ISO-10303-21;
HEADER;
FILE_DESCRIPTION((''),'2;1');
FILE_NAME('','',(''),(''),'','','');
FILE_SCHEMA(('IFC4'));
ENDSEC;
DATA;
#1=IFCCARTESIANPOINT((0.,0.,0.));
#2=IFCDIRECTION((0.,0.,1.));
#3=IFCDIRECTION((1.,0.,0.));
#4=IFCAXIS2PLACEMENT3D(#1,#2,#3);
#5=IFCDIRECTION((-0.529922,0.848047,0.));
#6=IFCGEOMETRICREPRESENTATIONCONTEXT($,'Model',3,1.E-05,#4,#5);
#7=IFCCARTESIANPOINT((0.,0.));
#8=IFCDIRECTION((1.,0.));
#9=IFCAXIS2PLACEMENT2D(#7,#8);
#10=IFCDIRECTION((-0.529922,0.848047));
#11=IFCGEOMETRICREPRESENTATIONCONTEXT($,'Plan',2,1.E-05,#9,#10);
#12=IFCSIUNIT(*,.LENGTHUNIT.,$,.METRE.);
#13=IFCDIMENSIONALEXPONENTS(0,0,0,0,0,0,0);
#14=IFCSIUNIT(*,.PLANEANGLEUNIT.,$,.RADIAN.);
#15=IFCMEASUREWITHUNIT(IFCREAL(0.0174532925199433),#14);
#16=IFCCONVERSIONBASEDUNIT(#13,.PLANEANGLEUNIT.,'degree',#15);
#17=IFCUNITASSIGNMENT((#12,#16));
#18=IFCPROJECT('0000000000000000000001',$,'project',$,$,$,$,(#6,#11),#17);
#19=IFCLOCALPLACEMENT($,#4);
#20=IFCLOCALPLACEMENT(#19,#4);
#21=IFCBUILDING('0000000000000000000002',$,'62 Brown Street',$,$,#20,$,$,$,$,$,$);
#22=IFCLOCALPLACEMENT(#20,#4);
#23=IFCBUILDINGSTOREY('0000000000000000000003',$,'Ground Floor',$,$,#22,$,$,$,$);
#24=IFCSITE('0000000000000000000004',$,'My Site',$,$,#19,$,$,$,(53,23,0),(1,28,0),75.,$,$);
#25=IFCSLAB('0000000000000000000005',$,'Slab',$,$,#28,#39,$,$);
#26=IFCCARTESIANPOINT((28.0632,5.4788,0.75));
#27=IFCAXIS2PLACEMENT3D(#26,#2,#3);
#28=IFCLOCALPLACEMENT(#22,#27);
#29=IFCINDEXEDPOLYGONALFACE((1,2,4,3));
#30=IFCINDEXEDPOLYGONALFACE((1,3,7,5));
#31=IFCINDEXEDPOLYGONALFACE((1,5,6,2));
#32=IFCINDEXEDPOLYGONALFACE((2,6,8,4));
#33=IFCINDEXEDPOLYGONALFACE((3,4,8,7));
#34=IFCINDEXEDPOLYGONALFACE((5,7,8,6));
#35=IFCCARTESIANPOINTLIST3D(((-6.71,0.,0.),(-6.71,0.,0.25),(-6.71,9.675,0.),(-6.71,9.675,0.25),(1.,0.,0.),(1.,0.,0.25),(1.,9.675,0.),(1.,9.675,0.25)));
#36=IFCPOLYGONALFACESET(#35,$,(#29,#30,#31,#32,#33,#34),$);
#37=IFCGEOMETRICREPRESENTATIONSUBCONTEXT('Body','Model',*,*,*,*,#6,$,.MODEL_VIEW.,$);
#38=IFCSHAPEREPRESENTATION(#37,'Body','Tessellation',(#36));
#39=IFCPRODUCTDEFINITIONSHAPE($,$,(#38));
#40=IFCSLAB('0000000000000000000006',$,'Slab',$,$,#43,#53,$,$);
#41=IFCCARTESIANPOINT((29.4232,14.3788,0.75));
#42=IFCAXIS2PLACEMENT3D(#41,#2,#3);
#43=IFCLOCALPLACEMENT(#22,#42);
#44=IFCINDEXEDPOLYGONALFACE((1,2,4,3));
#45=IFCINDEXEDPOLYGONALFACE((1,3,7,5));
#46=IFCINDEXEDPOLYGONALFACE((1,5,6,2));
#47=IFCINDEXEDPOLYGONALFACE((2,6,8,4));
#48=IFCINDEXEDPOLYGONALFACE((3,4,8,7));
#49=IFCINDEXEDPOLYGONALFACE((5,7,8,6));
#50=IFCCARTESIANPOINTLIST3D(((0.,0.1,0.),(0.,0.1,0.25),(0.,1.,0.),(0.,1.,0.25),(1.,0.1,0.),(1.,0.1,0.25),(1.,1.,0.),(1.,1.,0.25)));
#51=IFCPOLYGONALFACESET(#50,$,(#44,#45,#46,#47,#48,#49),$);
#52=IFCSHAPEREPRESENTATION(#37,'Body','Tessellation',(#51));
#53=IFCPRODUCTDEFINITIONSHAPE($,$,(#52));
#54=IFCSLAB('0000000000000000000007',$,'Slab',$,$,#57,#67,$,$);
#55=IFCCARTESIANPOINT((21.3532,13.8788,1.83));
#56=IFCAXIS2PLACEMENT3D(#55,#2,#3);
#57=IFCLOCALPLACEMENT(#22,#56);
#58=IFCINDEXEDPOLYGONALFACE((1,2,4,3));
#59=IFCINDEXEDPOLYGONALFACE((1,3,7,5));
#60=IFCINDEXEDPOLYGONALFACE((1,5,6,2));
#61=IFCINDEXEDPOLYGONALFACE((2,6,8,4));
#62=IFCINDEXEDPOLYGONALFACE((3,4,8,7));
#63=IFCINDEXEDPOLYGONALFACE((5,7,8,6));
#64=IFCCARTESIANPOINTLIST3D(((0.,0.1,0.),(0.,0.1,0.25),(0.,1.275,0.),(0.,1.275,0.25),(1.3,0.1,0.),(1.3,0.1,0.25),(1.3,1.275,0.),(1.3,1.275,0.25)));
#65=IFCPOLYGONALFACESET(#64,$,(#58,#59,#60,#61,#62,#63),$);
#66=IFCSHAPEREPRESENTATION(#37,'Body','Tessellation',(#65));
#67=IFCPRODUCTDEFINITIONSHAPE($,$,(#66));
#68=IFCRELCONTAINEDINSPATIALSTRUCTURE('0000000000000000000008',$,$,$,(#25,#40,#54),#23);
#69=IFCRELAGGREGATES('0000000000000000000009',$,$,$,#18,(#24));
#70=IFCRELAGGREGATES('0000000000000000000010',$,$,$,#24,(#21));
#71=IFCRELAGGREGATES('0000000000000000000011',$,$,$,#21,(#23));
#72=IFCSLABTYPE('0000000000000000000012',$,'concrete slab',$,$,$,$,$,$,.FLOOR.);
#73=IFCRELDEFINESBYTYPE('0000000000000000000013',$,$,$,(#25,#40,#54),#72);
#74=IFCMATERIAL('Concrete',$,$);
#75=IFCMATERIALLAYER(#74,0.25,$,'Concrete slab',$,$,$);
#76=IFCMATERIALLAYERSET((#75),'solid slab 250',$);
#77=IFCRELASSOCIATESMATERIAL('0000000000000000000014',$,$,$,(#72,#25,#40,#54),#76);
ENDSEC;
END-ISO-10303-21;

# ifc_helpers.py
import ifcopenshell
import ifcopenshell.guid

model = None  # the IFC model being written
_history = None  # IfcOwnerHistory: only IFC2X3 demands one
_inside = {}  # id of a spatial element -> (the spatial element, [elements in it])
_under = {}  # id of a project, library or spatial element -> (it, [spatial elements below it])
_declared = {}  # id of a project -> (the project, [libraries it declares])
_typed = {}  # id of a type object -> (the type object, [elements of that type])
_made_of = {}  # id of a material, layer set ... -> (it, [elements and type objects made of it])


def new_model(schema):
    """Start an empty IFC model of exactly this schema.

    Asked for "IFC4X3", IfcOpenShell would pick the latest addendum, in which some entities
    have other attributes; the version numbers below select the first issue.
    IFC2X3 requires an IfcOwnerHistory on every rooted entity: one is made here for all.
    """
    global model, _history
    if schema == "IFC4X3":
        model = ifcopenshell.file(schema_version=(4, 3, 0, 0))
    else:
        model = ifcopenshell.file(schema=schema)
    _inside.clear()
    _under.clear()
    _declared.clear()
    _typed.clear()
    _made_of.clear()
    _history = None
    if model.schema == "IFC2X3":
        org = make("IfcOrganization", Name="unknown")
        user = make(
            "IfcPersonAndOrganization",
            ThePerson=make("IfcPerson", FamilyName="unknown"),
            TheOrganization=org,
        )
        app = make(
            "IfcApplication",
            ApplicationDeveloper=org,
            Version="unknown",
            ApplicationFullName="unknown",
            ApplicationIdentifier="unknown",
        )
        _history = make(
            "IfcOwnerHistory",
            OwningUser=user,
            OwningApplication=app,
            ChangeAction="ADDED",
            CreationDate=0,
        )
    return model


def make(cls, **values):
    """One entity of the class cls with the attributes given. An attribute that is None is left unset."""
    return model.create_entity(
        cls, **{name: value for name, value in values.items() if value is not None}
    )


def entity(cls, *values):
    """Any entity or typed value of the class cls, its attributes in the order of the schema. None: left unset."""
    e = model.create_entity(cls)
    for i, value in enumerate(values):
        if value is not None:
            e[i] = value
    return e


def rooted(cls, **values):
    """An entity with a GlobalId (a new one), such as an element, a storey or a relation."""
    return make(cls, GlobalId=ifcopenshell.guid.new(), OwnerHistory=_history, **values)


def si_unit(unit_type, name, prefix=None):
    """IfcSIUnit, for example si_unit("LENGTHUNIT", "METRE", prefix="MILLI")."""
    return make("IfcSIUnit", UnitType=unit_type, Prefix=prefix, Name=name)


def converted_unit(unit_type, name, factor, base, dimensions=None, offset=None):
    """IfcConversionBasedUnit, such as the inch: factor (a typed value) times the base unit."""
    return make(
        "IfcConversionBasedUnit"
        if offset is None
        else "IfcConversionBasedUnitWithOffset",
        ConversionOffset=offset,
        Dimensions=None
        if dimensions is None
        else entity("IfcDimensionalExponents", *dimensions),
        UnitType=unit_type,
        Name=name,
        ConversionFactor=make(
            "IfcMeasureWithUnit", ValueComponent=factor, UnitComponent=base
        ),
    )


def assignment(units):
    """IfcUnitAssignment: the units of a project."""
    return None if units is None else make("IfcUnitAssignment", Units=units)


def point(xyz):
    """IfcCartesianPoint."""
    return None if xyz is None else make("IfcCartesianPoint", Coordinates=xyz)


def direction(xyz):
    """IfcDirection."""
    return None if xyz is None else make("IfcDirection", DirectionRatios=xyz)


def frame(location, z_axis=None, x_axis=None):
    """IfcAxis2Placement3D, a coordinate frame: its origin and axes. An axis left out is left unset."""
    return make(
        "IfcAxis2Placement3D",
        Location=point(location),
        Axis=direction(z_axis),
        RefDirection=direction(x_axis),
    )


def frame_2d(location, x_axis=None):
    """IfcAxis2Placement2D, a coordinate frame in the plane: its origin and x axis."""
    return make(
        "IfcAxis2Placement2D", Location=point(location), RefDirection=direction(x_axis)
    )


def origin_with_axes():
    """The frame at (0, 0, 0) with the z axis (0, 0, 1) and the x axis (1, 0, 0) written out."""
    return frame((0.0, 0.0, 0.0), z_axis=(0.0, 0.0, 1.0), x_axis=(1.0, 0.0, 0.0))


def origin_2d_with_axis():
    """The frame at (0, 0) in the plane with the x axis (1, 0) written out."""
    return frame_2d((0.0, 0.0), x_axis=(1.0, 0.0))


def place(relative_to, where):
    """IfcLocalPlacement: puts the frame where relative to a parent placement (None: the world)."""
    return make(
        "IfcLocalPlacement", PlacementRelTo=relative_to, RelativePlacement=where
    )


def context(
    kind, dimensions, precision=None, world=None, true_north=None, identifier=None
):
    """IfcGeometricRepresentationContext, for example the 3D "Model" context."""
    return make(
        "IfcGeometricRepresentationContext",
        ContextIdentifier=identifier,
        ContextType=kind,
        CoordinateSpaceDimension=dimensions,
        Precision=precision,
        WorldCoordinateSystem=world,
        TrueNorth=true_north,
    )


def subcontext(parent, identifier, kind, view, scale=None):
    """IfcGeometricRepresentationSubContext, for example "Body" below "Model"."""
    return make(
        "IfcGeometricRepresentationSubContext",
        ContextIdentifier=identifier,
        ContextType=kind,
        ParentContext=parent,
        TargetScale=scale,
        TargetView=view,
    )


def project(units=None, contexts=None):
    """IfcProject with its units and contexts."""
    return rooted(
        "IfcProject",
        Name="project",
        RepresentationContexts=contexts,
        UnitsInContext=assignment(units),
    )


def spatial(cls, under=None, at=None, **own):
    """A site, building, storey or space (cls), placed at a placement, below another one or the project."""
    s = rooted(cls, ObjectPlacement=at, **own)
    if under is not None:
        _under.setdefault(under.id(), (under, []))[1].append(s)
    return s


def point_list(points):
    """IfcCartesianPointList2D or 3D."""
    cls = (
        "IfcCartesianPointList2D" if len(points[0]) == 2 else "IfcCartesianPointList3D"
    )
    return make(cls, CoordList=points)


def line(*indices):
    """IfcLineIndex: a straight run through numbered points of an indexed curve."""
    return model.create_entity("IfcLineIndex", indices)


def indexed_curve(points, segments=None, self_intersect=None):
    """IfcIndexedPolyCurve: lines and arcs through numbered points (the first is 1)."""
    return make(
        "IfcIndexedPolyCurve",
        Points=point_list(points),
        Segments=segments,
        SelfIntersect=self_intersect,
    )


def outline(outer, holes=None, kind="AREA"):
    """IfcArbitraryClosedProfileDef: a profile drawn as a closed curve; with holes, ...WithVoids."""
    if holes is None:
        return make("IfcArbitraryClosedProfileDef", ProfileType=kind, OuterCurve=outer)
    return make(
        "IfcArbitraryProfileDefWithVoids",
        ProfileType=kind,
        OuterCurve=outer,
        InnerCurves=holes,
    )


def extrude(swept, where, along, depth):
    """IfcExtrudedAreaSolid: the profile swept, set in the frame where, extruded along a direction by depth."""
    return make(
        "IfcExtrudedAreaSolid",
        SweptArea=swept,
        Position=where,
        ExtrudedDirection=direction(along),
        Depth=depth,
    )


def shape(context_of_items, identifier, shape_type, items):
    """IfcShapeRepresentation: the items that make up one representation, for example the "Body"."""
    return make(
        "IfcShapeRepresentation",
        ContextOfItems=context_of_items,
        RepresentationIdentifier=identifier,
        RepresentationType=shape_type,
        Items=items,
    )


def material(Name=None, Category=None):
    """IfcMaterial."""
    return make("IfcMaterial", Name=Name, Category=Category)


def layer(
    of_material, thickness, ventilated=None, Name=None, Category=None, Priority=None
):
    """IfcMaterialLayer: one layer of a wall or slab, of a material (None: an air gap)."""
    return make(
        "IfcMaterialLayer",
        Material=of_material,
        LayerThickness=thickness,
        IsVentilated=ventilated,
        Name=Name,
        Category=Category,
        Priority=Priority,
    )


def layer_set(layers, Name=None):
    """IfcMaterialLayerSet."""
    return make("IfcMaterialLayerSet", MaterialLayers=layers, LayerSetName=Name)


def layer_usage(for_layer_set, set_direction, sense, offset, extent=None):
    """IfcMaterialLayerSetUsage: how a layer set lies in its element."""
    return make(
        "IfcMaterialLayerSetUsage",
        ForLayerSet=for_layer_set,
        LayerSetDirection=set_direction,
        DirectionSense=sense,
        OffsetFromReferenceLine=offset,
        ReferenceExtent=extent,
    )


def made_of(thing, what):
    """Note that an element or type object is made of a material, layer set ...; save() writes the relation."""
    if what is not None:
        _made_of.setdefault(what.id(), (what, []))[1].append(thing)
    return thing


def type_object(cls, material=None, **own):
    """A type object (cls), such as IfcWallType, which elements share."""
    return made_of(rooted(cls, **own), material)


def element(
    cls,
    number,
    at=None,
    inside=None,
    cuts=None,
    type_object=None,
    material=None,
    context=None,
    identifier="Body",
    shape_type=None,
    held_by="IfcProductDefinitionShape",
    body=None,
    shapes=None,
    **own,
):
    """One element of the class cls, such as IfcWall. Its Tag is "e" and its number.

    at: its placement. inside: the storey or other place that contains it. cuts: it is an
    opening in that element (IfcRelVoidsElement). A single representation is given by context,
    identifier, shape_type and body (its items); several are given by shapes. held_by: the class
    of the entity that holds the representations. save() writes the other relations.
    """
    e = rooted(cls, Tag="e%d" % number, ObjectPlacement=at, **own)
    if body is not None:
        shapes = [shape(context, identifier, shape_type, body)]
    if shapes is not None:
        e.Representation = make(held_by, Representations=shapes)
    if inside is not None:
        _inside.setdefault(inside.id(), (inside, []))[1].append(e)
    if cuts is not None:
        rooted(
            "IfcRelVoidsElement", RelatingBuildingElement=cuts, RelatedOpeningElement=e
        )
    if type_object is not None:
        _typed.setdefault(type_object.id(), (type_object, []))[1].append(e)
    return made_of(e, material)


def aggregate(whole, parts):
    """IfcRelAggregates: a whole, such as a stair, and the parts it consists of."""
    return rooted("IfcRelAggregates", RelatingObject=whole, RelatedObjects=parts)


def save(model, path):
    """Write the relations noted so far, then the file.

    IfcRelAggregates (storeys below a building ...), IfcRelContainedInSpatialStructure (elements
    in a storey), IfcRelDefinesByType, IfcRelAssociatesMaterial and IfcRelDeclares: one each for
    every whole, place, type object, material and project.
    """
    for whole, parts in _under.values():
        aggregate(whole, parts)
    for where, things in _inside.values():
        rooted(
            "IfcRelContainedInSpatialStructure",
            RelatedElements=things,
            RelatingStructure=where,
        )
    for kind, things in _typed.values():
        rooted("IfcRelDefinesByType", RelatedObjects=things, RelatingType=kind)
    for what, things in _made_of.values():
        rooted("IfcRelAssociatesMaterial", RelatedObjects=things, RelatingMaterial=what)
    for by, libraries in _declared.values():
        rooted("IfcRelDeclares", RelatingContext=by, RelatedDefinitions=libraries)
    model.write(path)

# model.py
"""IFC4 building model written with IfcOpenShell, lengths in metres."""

from ifc_helpers import new_model, entity, si_unit, converted_unit, direction, frame, origin_with_axes, origin_2d_with_axis, place, context, subcontext, project, spatial, line, indexed_curve, outline, extrude, material, layer, layer_set, layer_usage, type_object, element, save


model = new_model("IFC4")

# Units and contexts
model_context = context("Model", 3, precision=1e-05, world=origin_with_axes(), true_north=direction((-0.529922, 0.848047, 0.0)))
plan_context = context("Plan", 2, precision=1e-05, world=origin_2d_with_axis(), true_north=direction((-0.529922, 0.848047)))
body_context = subcontext(model_context, "Body", "Model", "MODEL_VIEW")
ifc_project = project(units=[si_unit("LENGTHUNIT", "METRE"), converted_unit("PLANEANGLEUNIT", "degree", entity("IfcReal", 0.0174532925199433), si_unit("PLANEANGLEUNIT", "RADIAN"), dimensions=[0, 0, 0, 0, 0, 0, 0])], contexts=[model_context, plan_context])

# Site, building, storey
site_placement = place(None, origin_with_axes())
site = spatial("IfcSite", under=ifc_project, at=site_placement, Name="My Site", RefLatitude=(53, 23, 0), RefLongitude=(1, 28, 0), RefElevation=75.0)
building_placement = place(site_placement, origin_with_axes())
building = spatial("IfcBuilding", under=site, at=building_placement, Name="62 Brown Street")
storey_placement = place(building_placement, origin_with_axes())
storey = spatial("IfcBuildingStorey", under=building, at=storey_placement, Name="Ground Floor")

# Shared definitions
ifc_material_1 = material(Name="Concrete")

# Slabs
ifc_layer_1 = layer(ifc_material_1, 0.25, Name="Concrete slab")
ifc_layer_set_1 = layer_set([ifc_layer_1], Name="solid slab 250")
slab_type = type_object("IfcSlabType", Name="concrete slab", PredefinedType="FLOOR", material=ifc_layer_set_1)
ifc_layer_usage_1 = layer_usage(ifc_layer_set_1, "AXIS3", "POSITIVE", 0.0)
slab_1_placement = place(storey_placement, frame((28.0632, 5.4788, 0.75), z_axis=(0.0, 0.0, 1.0), x_axis=(1.0, 0.0, 0.0)))
element("IfcSlab", 1, at=slab_1_placement, inside=storey, type_object=slab_type, material=ifc_layer_usage_1, Name="Slab", context=body_context, shape_type="SweptSolid", body=[
    extrude(outline(indexed_curve([(-6.71, 0.0), (-6.71, 9.675), (1.0, 9.675), (1.0, 0.0), (-6.71, 0.0)])), None, (0.0, 0.0, 1.0), 0.25),
])
ifc_layer_usage_2 = layer_usage(ifc_layer_set_1, "AXIS3", "POSITIVE", 0.0)
slab_2_placement = place(storey_placement, frame((29.4232, 14.3788, 0.75), z_axis=(0.0, 0.0, 1.0), x_axis=(1.0, 0.0, 0.0)))
element("IfcSlab", 2, at=slab_2_placement, inside=storey, type_object=slab_type, material=ifc_layer_usage_2, Name="Slab", context=body_context, shape_type="SweptSolid", body=[
    extrude(outline(indexed_curve([(1.0, 1.0), (1.0, 0.1), (0.0, 0.1), (0.0, 1.0)], segments=[line(3, 2), line(2, 1), line(1, 4), line(4, 3)], self_intersect=False)), None, (0.0, 0.0, 1.0), 0.25),
])
ifc_layer_usage_3 = layer_usage(ifc_layer_set_1, "AXIS3", "POSITIVE", 0.0)
slab_3_placement = place(storey_placement, frame((21.3532, 13.8788, 1.83), z_axis=(0.0, 0.0, 1.0), x_axis=(1.0, 0.0, 0.0)))
element("IfcSlab", 3, at=slab_3_placement, inside=storey, type_object=slab_type, material=ifc_layer_usage_3, Name="Slab", context=body_context, shape_type="SweptSolid", body=[
    extrude(outline(indexed_curve([(0.0, 0.1), (1.3, 0.1), (1.3, 1.275), (0.0, 1.275), (0.0, 0.1)])), None, (0.0, 0.0, 1.0), 0.25),
])

save(model, "model.ifc")
